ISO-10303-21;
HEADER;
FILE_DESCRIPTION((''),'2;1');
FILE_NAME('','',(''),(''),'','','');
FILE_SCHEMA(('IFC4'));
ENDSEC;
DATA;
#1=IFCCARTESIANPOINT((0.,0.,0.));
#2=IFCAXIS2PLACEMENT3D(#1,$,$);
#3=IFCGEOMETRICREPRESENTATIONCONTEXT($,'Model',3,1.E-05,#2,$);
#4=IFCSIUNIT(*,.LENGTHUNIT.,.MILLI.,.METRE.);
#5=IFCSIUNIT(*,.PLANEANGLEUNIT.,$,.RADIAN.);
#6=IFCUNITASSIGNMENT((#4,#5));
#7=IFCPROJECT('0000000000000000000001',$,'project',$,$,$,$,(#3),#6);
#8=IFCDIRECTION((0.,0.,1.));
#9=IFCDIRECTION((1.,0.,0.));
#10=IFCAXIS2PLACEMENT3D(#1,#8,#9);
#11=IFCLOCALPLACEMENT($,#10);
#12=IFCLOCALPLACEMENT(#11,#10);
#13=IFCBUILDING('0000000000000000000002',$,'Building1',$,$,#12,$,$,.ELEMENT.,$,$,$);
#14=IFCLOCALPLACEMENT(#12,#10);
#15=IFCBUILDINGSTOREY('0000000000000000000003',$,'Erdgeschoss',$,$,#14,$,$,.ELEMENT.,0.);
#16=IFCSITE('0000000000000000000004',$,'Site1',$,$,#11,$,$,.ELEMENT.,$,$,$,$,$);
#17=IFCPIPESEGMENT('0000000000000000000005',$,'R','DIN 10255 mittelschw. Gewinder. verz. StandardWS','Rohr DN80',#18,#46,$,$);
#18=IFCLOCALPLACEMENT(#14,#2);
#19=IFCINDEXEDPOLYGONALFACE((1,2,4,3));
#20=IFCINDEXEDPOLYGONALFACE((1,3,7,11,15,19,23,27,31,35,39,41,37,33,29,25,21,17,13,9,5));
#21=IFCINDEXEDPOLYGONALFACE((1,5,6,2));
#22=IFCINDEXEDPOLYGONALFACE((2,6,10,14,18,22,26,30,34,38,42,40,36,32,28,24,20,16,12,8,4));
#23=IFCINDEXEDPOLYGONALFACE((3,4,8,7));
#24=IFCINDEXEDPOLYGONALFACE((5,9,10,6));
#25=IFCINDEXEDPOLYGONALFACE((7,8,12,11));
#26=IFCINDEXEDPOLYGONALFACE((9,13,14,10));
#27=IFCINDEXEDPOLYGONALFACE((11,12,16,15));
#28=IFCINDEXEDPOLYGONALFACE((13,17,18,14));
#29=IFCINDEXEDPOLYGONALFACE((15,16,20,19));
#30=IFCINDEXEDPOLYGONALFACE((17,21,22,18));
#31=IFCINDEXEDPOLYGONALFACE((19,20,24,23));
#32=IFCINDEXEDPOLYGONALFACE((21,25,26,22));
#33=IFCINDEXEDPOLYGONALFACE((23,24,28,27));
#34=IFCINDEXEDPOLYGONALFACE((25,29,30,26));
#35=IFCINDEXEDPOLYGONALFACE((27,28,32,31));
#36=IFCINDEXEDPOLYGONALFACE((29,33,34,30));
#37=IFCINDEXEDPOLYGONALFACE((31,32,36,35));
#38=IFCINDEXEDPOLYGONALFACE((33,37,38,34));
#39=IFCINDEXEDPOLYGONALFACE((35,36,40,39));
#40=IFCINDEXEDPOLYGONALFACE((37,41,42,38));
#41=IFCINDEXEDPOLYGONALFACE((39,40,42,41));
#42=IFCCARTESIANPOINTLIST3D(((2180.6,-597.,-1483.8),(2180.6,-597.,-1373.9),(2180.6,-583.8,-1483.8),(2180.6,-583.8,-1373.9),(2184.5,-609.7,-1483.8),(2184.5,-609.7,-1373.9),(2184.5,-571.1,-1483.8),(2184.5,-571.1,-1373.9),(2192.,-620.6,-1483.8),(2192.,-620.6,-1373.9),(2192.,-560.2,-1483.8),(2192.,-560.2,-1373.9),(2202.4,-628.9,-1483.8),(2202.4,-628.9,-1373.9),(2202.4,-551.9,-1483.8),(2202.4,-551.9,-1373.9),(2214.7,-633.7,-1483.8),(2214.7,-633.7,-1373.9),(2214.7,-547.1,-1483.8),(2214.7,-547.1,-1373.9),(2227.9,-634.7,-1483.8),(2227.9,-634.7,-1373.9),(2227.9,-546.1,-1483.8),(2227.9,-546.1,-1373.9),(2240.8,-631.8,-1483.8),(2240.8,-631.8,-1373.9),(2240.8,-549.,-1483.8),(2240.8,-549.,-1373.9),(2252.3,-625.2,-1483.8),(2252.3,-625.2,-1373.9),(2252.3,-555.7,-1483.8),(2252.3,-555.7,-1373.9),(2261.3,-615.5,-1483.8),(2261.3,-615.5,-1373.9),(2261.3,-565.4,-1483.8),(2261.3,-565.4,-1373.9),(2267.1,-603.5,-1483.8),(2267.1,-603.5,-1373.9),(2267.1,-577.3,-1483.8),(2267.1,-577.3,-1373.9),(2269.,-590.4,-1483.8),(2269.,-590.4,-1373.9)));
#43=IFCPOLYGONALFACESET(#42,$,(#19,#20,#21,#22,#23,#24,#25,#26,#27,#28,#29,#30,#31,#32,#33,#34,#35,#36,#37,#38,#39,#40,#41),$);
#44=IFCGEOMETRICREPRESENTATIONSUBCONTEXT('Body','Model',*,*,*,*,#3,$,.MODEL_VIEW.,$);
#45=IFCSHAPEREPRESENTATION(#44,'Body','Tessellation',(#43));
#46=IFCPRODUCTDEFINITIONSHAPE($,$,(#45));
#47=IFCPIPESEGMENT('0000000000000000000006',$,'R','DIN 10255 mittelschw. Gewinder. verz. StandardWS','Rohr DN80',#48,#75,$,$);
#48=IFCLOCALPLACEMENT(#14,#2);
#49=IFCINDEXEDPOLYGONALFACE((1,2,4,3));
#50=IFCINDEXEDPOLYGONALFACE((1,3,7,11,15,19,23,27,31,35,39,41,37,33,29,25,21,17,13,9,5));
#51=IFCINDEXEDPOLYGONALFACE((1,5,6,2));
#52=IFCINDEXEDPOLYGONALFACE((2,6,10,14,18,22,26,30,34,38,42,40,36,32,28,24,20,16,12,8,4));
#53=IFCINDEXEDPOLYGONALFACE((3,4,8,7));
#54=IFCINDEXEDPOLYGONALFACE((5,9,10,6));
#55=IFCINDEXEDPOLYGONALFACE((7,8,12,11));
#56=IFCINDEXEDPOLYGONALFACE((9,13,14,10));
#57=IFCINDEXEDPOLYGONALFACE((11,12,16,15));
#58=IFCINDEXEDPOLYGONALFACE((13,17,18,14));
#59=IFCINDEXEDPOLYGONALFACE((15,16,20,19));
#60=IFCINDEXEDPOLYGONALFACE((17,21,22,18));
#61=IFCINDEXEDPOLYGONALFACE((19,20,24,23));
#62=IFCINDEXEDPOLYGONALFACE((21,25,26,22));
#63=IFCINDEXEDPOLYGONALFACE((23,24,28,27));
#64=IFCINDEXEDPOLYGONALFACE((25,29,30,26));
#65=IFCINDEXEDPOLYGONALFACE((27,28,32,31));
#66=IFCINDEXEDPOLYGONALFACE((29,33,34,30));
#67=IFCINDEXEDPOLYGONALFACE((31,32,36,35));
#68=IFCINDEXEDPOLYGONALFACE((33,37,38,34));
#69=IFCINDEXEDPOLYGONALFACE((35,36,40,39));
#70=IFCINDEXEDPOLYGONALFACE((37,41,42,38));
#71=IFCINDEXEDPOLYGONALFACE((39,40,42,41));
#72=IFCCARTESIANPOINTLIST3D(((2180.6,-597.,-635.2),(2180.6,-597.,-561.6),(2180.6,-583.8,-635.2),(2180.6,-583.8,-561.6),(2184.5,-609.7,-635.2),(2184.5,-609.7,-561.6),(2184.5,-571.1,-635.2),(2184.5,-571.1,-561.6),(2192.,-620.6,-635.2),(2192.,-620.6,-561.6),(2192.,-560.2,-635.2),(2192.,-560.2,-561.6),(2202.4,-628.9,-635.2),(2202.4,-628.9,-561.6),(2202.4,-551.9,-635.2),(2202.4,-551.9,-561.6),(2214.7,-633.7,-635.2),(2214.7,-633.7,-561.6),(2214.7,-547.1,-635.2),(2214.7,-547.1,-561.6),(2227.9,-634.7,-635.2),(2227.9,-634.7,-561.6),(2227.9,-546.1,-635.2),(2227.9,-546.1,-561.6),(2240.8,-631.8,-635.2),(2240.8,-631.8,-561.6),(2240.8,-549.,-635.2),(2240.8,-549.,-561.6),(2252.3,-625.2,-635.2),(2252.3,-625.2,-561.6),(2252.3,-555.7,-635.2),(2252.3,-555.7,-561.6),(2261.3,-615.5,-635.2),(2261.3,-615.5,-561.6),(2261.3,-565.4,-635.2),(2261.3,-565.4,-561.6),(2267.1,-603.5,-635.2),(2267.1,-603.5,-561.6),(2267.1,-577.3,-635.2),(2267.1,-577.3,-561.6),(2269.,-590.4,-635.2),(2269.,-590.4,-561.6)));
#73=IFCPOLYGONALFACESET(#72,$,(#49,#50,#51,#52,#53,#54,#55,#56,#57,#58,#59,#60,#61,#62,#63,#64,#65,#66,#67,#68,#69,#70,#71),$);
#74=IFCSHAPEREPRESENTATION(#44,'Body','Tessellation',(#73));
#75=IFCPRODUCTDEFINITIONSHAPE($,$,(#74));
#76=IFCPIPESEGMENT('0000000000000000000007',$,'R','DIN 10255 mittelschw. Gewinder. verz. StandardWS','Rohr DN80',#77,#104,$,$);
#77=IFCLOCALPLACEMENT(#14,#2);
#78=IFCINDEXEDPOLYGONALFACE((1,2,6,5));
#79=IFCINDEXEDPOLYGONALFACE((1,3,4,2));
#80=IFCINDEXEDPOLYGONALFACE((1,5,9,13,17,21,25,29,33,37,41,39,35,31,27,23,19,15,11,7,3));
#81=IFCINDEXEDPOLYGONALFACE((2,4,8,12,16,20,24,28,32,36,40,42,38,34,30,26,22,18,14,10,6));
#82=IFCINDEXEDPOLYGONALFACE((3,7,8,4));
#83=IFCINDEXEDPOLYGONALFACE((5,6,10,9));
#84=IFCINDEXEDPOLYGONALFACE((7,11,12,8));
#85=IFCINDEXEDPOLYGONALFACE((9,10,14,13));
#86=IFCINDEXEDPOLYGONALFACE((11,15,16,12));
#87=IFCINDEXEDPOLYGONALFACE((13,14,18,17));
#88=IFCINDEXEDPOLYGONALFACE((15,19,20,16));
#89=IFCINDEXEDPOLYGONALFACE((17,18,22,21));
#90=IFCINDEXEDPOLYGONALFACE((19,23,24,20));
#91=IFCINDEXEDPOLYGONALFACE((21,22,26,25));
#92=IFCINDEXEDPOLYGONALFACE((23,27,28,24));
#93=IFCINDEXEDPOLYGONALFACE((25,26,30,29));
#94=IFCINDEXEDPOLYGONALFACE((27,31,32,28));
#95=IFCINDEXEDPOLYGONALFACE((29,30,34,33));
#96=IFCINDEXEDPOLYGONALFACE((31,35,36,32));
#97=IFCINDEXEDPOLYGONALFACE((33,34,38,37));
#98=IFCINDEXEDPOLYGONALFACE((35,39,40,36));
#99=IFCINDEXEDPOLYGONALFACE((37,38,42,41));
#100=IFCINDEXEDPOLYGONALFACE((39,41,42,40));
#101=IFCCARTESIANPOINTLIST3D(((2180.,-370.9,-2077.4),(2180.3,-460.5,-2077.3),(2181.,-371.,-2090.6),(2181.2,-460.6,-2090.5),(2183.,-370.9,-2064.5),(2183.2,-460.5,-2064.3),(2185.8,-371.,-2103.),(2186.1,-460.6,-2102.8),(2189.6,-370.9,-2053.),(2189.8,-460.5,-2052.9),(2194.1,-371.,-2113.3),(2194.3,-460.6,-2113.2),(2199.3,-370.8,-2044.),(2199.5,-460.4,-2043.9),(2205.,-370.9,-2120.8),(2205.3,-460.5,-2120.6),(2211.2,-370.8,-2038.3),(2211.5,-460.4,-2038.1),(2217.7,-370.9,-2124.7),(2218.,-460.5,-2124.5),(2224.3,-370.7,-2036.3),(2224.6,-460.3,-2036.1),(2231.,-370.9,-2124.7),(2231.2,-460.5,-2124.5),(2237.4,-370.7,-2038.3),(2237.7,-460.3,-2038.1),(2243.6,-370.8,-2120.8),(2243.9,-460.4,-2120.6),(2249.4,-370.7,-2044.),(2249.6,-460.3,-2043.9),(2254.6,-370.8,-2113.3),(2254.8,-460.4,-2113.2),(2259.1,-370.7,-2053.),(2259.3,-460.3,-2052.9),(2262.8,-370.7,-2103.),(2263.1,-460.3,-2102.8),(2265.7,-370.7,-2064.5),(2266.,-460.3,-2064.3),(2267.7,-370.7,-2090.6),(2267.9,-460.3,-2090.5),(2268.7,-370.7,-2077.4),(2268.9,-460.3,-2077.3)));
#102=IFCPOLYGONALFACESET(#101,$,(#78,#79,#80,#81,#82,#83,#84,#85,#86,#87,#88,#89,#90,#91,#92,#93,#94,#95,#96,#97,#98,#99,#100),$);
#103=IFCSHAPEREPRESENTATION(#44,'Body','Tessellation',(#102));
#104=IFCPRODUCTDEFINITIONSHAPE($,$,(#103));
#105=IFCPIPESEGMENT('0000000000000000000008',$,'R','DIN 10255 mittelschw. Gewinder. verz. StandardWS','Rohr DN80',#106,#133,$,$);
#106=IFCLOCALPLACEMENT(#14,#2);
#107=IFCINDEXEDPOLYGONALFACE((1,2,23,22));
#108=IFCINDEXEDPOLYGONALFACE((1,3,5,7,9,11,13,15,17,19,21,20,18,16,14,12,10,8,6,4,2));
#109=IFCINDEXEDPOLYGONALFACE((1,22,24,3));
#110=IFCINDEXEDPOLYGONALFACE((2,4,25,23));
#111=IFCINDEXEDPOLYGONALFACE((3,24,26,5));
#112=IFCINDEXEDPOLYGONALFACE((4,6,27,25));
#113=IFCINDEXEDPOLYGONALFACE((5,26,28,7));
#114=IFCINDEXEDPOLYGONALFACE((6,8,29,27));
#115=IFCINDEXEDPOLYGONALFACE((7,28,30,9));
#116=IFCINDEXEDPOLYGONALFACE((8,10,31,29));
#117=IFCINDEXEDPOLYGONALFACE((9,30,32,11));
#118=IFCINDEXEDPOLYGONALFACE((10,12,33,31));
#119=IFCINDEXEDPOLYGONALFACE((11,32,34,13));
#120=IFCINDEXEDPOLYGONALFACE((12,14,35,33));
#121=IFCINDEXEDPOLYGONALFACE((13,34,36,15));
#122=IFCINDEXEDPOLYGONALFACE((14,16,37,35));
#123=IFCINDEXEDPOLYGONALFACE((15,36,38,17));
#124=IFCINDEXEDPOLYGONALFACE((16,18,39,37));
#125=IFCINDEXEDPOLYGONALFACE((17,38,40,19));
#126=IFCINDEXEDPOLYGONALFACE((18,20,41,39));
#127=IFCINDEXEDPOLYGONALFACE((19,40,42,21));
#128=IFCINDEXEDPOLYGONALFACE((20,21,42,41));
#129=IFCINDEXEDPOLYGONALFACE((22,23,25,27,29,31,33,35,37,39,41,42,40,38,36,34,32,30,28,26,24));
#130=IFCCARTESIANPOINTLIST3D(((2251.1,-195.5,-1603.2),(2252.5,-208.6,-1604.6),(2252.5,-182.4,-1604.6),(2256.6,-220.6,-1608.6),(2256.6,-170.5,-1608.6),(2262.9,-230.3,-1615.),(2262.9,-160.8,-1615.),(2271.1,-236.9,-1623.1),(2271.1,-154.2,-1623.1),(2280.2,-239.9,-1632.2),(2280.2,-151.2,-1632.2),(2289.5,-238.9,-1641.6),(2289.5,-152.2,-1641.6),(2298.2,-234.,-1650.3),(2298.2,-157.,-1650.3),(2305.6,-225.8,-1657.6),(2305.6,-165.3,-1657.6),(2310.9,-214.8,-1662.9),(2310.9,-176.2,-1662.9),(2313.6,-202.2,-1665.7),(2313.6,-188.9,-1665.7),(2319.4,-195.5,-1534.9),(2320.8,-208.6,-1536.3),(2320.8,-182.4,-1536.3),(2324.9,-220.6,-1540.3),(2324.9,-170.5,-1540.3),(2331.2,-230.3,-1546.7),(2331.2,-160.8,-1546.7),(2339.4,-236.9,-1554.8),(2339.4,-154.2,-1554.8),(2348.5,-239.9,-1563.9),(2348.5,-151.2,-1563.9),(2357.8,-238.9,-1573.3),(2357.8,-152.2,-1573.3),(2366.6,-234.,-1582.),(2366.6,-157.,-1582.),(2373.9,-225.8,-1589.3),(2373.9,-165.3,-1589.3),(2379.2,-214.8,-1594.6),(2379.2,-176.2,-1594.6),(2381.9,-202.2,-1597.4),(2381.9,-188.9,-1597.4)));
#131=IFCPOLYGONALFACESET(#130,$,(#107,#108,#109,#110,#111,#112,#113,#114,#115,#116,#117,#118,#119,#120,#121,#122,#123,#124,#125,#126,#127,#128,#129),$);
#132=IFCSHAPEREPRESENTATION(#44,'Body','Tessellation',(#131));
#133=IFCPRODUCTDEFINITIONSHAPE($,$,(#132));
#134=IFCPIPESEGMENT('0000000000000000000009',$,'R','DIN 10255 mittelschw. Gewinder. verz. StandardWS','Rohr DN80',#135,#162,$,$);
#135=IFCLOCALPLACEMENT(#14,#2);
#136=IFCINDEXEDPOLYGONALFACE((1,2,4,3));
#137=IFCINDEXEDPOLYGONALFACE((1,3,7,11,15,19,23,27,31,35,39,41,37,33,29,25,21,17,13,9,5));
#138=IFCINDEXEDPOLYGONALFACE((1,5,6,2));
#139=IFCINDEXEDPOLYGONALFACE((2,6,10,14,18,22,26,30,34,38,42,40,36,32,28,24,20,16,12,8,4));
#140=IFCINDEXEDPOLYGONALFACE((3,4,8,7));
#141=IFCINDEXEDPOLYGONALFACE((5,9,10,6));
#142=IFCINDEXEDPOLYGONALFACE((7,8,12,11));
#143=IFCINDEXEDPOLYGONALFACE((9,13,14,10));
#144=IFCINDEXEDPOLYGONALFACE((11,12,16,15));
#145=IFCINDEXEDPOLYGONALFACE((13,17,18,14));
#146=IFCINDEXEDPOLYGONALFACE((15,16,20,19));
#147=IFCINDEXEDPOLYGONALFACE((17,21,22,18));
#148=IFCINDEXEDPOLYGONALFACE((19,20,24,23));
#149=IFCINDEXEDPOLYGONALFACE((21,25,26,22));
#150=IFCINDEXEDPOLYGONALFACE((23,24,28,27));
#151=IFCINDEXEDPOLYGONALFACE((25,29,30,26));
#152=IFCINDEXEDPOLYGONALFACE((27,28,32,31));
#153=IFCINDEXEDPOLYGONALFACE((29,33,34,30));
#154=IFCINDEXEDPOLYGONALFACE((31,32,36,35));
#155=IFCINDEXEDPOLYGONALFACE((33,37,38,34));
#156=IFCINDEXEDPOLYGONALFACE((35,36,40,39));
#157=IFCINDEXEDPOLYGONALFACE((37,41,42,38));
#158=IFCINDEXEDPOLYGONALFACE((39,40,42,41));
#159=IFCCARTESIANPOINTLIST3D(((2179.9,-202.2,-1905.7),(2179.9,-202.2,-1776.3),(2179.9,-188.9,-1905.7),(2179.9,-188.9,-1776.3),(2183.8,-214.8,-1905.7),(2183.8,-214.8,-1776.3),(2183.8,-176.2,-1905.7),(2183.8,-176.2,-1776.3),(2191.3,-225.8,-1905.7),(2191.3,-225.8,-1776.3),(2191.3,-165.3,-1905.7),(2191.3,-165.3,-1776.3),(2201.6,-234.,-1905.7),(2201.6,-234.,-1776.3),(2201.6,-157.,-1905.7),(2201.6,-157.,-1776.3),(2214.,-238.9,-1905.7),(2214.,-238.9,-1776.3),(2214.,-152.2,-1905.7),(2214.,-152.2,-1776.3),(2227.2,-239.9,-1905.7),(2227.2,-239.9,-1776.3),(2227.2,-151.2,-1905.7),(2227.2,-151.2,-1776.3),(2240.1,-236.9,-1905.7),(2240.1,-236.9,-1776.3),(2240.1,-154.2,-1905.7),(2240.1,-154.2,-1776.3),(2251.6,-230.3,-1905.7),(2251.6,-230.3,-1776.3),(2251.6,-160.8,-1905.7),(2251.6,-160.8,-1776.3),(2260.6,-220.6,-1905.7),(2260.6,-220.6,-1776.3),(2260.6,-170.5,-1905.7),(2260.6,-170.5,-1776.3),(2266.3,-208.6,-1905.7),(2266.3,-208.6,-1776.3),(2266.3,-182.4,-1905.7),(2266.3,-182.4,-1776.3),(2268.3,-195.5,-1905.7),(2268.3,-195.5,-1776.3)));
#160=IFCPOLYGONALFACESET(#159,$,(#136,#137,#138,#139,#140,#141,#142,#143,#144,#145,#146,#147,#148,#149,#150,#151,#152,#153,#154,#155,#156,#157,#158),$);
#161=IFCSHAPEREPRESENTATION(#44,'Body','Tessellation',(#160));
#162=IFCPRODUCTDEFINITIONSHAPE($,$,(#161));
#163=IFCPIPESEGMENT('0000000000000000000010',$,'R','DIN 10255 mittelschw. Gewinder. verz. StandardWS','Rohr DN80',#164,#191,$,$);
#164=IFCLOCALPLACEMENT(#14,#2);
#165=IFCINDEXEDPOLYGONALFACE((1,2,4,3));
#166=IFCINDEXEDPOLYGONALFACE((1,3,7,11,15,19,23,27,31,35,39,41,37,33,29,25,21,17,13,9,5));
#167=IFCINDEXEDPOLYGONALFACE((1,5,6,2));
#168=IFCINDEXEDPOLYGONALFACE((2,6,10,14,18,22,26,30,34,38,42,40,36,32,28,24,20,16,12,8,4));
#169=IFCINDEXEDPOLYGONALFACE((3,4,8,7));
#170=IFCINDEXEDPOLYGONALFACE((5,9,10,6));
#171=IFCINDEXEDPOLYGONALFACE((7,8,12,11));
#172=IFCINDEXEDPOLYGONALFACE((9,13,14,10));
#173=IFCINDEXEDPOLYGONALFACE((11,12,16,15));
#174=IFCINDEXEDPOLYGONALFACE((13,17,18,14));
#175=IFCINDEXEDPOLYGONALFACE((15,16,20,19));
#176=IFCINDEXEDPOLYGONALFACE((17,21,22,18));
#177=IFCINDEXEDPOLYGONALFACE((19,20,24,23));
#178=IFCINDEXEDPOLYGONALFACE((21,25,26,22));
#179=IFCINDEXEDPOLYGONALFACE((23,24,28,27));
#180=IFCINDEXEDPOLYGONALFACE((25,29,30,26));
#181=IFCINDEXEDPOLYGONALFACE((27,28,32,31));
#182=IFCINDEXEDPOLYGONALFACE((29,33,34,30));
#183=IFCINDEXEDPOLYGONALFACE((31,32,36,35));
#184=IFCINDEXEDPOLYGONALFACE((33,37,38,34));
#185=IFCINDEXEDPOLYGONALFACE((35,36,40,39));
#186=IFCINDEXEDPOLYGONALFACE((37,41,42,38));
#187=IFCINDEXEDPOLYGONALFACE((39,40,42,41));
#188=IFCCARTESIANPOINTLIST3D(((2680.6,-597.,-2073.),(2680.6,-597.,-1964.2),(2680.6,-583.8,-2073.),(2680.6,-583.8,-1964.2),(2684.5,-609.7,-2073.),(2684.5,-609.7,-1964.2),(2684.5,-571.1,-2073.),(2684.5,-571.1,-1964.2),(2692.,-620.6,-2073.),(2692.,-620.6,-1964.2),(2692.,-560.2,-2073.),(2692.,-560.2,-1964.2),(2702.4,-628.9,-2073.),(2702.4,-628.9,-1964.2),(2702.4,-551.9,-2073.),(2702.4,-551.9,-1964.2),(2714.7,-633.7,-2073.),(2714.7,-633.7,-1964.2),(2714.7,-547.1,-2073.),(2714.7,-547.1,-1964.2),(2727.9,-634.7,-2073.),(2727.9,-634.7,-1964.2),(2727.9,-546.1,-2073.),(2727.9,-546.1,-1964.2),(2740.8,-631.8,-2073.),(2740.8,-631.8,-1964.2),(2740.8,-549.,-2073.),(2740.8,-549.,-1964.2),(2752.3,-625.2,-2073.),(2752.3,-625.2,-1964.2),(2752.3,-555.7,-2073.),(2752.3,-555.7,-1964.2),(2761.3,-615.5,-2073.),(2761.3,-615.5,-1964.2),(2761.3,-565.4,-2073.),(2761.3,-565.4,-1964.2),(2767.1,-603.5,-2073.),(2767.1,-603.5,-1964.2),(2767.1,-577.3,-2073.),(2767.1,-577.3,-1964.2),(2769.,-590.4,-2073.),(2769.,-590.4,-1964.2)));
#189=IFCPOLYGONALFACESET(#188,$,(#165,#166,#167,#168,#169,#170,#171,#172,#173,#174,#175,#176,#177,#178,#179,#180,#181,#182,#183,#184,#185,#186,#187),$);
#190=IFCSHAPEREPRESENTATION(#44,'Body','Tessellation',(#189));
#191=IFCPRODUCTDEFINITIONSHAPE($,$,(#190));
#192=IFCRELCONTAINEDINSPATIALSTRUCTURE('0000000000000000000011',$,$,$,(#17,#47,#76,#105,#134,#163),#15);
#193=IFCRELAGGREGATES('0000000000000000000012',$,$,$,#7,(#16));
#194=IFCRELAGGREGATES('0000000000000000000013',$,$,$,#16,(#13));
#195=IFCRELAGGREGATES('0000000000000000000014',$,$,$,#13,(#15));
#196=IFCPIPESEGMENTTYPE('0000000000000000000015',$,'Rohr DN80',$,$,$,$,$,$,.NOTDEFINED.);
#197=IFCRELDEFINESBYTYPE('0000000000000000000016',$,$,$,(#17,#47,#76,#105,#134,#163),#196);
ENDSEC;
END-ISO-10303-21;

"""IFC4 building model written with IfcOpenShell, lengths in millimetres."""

from ifc_helpers import new_model, si_unit, frame, origin, origin_with_axes, origin_2d_with_axis, place, context, subcontext, project, spatial, circle, extrude, type_object, element, save


model = new_model("IFC4")

# Units and contexts
model_context = context("Model", 3, precision=1e-05, world=origin())
body_context = subcontext(model_context, "Body", "Model", "MODEL_VIEW")
ifc_project = project(units=[si_unit("LENGTHUNIT", "METRE", prefix="MILLI"), si_unit("PLANEANGLEUNIT", "RADIAN")], contexts=[model_context])

# Site, building, storey
site_placement = place(None, origin_with_axes())
site = spatial("IfcSite", under=ifc_project, at=site_placement, Name="Site1", CompositionType="ELEMENT")
building_placement = place(site_placement, origin_with_axes())
building = spatial("IfcBuilding", under=site, at=building_placement, Name="Building1", CompositionType="ELEMENT")
storey_placement = place(building_placement, origin_with_axes())
storey = spatial("IfcBuildingStorey", under=building, at=storey_placement, Name="Erdgeschoss", CompositionType="ELEMENT", Elevation=0.0)

# Pipe segments
pipe_segment_type_1 = type_object("IfcPipeSegmentType", Name="Rohr DN80", PredefinedType="NOTDEFINED")
pipe_segment_1_placement = place(storey_placement, frame((2224.6, -590.6, -1428.8), z_axis=(0.0, 0.0, 1.0), x_axis=(1.0, 0.0, 0.0)))
element("IfcPipeSegment", 1, at=pipe_segment_1_placement, inside=storey, type_object=pipe_segment_type_1, Name="R", Description="DIN 10255 mittelschw. Gewinder. verz. StandardWS", ObjectType="Rohr DN80", context=body_context, shape_type="SolidModel", body=[
    extrude(circle(Radius=44.5, at=origin_2d_with_axis()), frame((0.0, 0.1, -55.0), z_axis=(0.0, 0.0, 1.0), x_axis=(1.0, 0.0, 0.0)), (0.0, 0.0, 1.0), 109.9),
])
pipe_segment_2_placement = place(storey_placement, frame((2224.6, -590.6, -598.4), z_axis=(0.0, 0.0, 1.0), x_axis=(1.0, 0.0, 0.0)))
element("IfcPipeSegment", 2, at=pipe_segment_2_placement, inside=storey, type_object=pipe_segment_type_1, Name="R", Description="DIN 10255 mittelschw. Gewinder. verz. StandardWS", ObjectType="Rohr DN80", context=body_context, shape_type="SolidModel", body=[
    extrude(circle(Radius=44.5, at=origin_2d_with_axis()), frame((0.0, 0.1, -36.8), z_axis=(0.0, 0.0, 1.0), x_axis=(1.0, 0.0, 0.0)), (0.0, 0.0, 1.0), 73.6),
])
pipe_segment_3_placement = place(storey_placement, frame((2224.6, -415.6, -2080.7), z_axis=(0.0, 0.0, 1.0), x_axis=(1.0, 0.0, 0.0)))
element("IfcPipeSegment", 3, at=pipe_segment_3_placement, inside=storey, type_object=pipe_segment_type_1, Name="R", Description="DIN 10255 mittelschw. Gewinder. verz. StandardWS", ObjectType="Rohr DN80", context=body_context, shape_type="SolidModel", body=[
    extrude(circle(Radius=44.5, at=origin_2d_with_axis()), frame((-0.3, 44.8, -0.1), z_axis=(0.002779, -0.999995, 0.001637), x_axis=(0.0, 0.0, 1.0)), (0.0, 0.0, 1.0), 89.6),
])
pipe_segment_4_placement = place(storey_placement, frame((2316.7, -195.7, -1600.4), z_axis=(0.0, 0.0, 1.0), x_axis=(1.0, 0.0, 0.0)))
element("IfcPipeSegment", 4, at=pipe_segment_4_placement, inside=storey, type_object=pipe_segment_type_1, Name="R", Description="DIN 10255 mittelschw. Gewinder. verz. StandardWS", ObjectType="Rohr DN80", context=body_context, shape_type="SolidModel", body=[
    extrude(circle(Radius=44.5, at=origin_2d_with_axis()), frame((34.2, 0.2, 34.2), z_axis=(-0.707107, 0.0, -0.707107), x_axis=(0.0, 0.0, 1.0)), (0.0, 0.0, 1.0), 96.6),
])
pipe_segment_5_placement = place(storey_placement, frame((2223.8, -195.7, -1841.0), z_axis=(0.0, 0.0, 1.0), x_axis=(1.0, 0.0, 0.0)))
element("IfcPipeSegment", 5, at=pipe_segment_5_placement, inside=storey, type_object=pipe_segment_type_1, Name="R", Description="DIN 10255 mittelschw. Gewinder. verz. StandardWS", ObjectType="Rohr DN80", context=body_context, shape_type="SolidModel", body=[
    extrude(circle(Radius=44.5, at=origin_2d_with_axis()), frame((0.0, 0.1, -64.7), z_axis=(0.0, 0.0, 1.0), x_axis=(1.0, 0.0, 0.0)), (0.0, 0.0, 1.0), 129.4),
])
pipe_segment_6_placement = place(storey_placement, frame((2724.6, -590.6, -2018.6), z_axis=(0.0, 0.0, 1.0), x_axis=(1.0, 0.0, 0.0)))
element("IfcPipeSegment", 6, at=pipe_segment_6_placement, inside=storey, type_object=pipe_segment_type_1, Name="R", Description="DIN 10255 mittelschw. Gewinder. verz. StandardWS", ObjectType="Rohr DN80", context=body_context, shape_type="SolidModel", body=[
    extrude(circle(Radius=44.5, at=origin_2d_with_axis()), frame((0.0, 0.1, -54.4), z_axis=(0.0, 0.0, 1.0), x_axis=(1.0, 0.0, 0.0)), (0.0, 0.0, 1.0), 108.8),
])

save(model, "model.ifc")
